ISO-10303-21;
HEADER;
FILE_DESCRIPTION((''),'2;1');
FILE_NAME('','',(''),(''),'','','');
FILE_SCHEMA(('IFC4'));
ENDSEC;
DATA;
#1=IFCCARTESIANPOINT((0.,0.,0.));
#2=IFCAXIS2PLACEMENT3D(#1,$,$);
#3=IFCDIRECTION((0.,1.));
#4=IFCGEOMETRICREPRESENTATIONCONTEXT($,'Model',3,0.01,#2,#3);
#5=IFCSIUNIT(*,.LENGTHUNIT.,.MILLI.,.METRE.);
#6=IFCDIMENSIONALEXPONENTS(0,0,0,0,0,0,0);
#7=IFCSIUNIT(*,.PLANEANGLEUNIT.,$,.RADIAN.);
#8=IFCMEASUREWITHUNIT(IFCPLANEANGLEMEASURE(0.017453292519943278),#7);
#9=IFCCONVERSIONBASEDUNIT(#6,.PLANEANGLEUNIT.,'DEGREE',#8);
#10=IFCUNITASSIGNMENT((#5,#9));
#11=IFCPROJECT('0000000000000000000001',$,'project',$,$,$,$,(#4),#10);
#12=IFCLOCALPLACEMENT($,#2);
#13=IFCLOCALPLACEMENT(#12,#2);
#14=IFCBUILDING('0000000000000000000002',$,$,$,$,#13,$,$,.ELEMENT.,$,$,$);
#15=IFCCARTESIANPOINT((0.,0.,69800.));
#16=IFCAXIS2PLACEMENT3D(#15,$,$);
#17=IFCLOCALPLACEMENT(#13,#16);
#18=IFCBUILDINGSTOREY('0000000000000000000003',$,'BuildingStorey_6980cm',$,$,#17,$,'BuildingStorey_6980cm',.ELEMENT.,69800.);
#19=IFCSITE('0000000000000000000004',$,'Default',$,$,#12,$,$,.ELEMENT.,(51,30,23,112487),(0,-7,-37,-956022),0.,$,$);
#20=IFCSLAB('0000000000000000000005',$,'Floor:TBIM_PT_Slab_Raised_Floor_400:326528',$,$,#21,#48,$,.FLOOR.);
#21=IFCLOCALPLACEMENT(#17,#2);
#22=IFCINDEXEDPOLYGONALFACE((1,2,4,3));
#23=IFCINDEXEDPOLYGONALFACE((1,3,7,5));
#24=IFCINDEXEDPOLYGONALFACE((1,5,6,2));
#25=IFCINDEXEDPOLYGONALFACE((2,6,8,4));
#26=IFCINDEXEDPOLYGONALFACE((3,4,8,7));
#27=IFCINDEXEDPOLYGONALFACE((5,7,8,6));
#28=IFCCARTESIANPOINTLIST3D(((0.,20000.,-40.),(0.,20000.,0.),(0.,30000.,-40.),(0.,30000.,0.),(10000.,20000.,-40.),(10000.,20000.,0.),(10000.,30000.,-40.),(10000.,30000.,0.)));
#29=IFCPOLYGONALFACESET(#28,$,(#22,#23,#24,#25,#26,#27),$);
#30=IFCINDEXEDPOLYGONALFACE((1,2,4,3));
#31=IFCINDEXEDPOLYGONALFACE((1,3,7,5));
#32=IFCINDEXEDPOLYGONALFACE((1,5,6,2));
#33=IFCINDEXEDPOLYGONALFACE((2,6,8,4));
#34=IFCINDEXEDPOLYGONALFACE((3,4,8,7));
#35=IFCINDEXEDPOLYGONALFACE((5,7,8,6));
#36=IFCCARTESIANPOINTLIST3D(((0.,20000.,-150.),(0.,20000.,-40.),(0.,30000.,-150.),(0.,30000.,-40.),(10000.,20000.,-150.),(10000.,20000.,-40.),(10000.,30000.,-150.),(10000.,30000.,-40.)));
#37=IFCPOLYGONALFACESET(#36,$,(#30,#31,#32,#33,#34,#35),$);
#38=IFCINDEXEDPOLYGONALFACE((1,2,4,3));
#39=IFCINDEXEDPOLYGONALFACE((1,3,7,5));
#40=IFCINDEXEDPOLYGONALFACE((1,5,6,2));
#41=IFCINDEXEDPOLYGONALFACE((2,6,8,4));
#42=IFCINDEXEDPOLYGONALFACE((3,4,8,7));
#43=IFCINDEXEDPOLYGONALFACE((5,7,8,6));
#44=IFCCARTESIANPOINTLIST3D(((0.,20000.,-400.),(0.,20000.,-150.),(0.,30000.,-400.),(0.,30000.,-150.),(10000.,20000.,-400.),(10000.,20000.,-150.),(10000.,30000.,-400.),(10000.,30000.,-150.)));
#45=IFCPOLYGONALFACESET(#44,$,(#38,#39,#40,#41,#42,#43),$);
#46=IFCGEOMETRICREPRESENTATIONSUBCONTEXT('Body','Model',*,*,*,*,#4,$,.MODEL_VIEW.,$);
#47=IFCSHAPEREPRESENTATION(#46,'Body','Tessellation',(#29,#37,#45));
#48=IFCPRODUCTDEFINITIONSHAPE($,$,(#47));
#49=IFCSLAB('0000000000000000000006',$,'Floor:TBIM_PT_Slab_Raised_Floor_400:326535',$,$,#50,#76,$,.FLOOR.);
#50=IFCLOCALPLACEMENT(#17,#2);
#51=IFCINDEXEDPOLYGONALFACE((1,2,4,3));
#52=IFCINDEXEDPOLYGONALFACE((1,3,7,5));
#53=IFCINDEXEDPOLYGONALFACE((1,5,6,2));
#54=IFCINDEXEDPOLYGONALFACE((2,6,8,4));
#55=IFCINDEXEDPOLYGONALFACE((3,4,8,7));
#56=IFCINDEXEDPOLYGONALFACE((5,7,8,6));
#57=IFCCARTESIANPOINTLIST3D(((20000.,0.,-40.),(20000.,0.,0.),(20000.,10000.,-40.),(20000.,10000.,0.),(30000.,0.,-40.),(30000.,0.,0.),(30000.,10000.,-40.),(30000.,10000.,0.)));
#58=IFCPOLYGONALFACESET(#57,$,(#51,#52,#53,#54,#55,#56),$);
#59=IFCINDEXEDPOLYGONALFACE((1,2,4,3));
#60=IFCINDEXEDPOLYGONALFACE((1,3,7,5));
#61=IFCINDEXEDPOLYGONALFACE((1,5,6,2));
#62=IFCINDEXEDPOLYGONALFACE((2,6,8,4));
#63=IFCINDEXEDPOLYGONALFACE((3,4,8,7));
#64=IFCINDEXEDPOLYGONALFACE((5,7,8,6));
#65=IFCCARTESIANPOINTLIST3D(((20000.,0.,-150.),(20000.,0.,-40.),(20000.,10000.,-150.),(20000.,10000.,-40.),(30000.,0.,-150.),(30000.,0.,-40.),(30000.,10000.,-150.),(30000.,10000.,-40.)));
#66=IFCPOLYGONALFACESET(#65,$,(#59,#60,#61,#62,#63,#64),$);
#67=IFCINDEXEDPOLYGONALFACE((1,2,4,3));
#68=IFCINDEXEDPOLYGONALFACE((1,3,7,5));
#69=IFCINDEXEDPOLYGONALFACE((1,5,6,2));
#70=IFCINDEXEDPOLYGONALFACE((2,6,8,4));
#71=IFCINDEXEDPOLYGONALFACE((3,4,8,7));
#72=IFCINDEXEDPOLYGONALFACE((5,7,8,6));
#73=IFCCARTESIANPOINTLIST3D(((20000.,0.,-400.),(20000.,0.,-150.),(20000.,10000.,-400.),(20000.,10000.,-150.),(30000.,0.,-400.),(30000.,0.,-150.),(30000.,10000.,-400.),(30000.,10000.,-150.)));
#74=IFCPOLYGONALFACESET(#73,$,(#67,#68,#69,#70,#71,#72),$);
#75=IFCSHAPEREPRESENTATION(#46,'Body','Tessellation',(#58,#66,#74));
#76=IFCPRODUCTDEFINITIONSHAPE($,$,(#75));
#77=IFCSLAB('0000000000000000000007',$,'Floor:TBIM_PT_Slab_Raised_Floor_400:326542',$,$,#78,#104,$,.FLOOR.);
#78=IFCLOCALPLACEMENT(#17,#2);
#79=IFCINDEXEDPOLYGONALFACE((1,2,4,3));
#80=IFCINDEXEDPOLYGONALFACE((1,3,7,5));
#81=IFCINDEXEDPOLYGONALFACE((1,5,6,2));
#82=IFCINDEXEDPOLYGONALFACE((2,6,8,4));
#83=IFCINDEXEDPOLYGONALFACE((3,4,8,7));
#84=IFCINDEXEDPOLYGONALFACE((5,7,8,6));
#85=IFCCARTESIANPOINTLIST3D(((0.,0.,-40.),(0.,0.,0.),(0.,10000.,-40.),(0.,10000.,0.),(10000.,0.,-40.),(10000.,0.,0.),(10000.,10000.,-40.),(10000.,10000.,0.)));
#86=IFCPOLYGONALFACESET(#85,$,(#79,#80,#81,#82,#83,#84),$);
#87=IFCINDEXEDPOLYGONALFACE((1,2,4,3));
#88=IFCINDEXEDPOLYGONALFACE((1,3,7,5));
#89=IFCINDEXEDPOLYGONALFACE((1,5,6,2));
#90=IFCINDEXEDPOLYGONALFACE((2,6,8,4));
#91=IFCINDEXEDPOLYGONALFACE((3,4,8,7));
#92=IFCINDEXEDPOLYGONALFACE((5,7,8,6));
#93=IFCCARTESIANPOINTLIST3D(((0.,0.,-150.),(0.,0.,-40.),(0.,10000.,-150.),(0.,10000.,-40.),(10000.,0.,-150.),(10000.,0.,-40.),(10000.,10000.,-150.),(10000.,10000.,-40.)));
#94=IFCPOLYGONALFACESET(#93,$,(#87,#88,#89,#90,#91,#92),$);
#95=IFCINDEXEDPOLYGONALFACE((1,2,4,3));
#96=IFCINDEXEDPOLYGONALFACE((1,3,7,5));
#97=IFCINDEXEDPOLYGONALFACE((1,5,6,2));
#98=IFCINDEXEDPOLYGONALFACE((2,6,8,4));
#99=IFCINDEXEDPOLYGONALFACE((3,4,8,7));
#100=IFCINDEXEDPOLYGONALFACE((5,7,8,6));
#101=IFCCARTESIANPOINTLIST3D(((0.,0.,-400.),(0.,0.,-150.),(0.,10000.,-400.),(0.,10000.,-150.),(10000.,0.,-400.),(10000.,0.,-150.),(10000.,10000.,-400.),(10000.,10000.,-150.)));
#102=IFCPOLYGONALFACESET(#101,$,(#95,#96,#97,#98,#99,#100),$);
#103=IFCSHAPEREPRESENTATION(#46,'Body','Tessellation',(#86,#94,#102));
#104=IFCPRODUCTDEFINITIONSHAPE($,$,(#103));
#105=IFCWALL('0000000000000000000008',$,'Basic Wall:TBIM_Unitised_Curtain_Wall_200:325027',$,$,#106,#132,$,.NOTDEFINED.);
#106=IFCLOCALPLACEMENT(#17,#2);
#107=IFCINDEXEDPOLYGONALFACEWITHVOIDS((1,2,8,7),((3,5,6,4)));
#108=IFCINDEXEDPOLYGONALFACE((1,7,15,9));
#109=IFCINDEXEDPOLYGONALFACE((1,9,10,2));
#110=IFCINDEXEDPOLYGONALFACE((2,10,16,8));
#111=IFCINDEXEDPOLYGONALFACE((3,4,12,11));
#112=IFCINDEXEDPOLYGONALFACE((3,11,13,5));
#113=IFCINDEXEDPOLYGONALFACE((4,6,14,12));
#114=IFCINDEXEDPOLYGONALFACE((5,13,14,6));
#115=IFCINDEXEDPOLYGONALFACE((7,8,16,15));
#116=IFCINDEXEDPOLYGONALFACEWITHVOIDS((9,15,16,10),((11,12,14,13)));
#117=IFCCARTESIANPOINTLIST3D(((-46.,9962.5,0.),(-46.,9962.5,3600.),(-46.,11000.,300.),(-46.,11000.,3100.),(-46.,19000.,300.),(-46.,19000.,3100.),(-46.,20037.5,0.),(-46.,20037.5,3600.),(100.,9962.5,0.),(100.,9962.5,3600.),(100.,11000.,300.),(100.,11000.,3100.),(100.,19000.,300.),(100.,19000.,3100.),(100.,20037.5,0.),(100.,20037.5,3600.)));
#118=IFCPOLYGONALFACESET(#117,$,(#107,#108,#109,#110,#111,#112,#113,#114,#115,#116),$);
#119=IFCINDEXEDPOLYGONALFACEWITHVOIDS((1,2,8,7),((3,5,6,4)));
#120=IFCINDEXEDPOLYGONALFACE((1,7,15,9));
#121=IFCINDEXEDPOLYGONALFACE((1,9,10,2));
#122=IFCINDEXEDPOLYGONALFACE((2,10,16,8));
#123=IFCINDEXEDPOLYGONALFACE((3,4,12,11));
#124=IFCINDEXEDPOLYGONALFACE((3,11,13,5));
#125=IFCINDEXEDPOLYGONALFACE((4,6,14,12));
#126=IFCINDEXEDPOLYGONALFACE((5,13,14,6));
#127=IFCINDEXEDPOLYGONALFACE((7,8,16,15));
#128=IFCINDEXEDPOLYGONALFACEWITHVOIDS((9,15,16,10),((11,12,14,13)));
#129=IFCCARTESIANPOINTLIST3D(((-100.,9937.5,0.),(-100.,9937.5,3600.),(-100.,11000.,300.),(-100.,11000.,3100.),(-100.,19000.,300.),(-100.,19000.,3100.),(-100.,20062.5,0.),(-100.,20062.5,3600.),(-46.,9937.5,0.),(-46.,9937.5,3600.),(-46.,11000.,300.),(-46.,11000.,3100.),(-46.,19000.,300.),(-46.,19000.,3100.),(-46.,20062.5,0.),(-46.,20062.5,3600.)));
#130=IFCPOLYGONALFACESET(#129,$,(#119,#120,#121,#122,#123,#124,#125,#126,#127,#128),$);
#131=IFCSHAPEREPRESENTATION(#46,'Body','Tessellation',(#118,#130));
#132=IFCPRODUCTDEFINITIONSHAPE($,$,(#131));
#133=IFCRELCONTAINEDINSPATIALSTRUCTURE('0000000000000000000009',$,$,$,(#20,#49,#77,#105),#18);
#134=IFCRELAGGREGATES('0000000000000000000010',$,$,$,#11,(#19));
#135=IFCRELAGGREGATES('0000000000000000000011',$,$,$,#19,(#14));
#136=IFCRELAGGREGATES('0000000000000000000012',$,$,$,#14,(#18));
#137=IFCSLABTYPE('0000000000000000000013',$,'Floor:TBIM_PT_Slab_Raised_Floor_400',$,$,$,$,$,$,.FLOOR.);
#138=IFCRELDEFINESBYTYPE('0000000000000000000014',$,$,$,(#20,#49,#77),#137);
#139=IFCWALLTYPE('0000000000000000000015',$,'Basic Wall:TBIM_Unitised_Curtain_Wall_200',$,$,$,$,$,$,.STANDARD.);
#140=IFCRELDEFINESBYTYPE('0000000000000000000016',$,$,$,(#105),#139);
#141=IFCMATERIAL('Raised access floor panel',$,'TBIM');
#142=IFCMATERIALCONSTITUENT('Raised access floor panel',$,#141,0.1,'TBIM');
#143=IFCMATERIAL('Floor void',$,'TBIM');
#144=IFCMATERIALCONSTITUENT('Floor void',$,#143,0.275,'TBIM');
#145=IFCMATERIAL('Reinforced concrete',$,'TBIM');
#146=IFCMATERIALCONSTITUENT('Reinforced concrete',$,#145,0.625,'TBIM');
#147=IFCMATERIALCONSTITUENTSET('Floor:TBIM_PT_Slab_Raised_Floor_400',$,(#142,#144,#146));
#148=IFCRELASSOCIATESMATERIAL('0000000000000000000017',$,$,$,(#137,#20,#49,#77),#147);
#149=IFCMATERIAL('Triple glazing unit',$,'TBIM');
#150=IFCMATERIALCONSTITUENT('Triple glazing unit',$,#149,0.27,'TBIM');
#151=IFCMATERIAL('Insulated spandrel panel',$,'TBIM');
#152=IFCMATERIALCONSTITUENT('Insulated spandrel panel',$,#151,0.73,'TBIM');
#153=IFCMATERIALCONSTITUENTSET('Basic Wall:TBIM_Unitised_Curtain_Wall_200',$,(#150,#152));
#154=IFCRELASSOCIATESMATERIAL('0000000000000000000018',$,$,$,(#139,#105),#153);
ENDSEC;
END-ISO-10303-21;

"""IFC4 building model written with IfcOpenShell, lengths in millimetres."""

from ifc_helpers import new_model, entity, si_unit, converted_unit, direction, frame, origin, place, context, subcontext, project, spatial, indexed_curve, outline, extrude, material, constituent, constituent_set, type_object, element, save


model = new_model("IFC4")

# Units and contexts
model_context = context("Model", 3, precision=0.01, world=origin(), true_north=direction((0.0, 1.0)))
body_context = subcontext(model_context, "Body", "Model", "MODEL_VIEW")
ifc_project = project(units=[si_unit("LENGTHUNIT", "METRE", prefix="MILLI"), converted_unit("PLANEANGLEUNIT", "DEGREE", entity("IfcPlaneAngleMeasure", 0.017453292519943278), si_unit("PLANEANGLEUNIT", "RADIAN"), dimensions=[0, 0, 0, 0, 0, 0, 0])], contexts=[model_context])

# Site, building, storey
site_placement = place(None, origin())
site = spatial("IfcSite", under=ifc_project, at=site_placement, Name="Default", CompositionType="ELEMENT", RefLatitude=(51, 30, 23, 112487), RefLongitude=(0, -7, -37, -956022), RefElevation=0.0)
building_placement = place(site_placement, origin())
building = spatial("IfcBuilding", under=site, at=building_placement, CompositionType="ELEMENT")
storey_placement = place(building_placement, frame((0.0, 0.0, 69800.0)))
storey = spatial("IfcBuildingStorey", under=building, at=storey_placement, Name="BuildingStorey_6980cm", LongName="BuildingStorey_6980cm", CompositionType="ELEMENT", Elevation=69800.0)

# Slabs
ifc_material_1 = material(Name="Raised access floor panel", Category="TBIM")
ifc_constituent_1 = constituent(ifc_material_1, Name="Raised access floor panel", Category="TBIM", fraction=0.1)
ifc_material_2 = material(Name="Floor void", Category="TBIM")
ifc_constituent_2 = constituent(ifc_material_2, Name="Floor void", Category="TBIM", fraction=0.275)
ifc_material_3 = material(Name="Reinforced concrete", Category="TBIM")
ifc_constituent_3 = constituent(ifc_material_3, Name="Reinforced concrete", Category="TBIM", fraction=0.625)
ifc_constituent_set_1 = constituent_set(constituents=[ifc_constituent_1, ifc_constituent_2, ifc_constituent_3], Name="Floor:TBIM_PT_Slab_Raised_Floor_400")
slab_type = type_object("IfcSlabType", Name="Floor:TBIM_PT_Slab_Raised_Floor_400", PredefinedType="FLOOR", material=ifc_constituent_set_1)
slab_1_placement = place(storey_placement, origin())
element("IfcSlab", 1, at=slab_1_placement, inside=storey, type_object=slab_type, material=ifc_constituent_set_1, Name="Floor:TBIM_PT_Slab_Raised_Floor_400:326528", PredefinedType="FLOOR", context=body_context, shape_type="SweptSolid", body=[
    extrude(outline(indexed_curve([(-5000.0, -5000.0), (5000.0, -5000.0), (5000.0, 5000.0), (-5000.0, 5000.0), (-5000.0, -5000.0)], self_intersect=False)), frame((5000.0, 25000.0, -40.0), z_axis=(0.0, 0.0, 1.0), x_axis=(-1.0, 0.0, 0.0)), (0.0, 0.0, 1.0), 40.0),
    extrude(outline(indexed_curve([(-5000.0, -5000.0), (5000.0, -5000.0), (5000.0, 5000.0), (-5000.0, 5000.0), (-5000.0, -5000.0)], self_intersect=False)), frame((5000.0, 25000.0, -150.0), z_axis=(0.0, 0.0, 1.0), x_axis=(-1.0, 0.0, 0.0)), (0.0, 0.0, 1.0), 110.0),
    extrude(outline(indexed_curve([(-5000.0, -5000.0), (5000.0, -5000.0), (5000.0, 5000.0), (-5000.0, 5000.0), (-5000.0, -5000.0)], self_intersect=False)), frame((5000.0, 25000.0, -400.0), z_axis=(0.0, 0.0, 1.0), x_axis=(-1.0, 0.0, 0.0)), (0.0, 0.0, 1.0), 250.0),
])
slab_2_placement = place(storey_placement, origin())
element("IfcSlab", 2, at=slab_2_placement, inside=storey, type_object=slab_type, material=ifc_constituent_set_1, Name="Floor:TBIM_PT_Slab_Raised_Floor_400:326535", PredefinedType="FLOOR", context=body_context, shape_type="SweptSolid", body=[
    extrude(outline(indexed_curve([(-5000.0, -5000.0), (5000.0, -5000.0), (5000.0, 5000.0), (-5000.0, 5000.0), (-5000.0, -5000.0)], self_intersect=False)), frame((25000.0, 5000.0, -40.0), z_axis=(0.0, 0.0, 1.0), x_axis=(-1.0, 0.0, 0.0)), (0.0, 0.0, 1.0), 40.0),
    extrude(outline(indexed_curve([(-5000.0, -5000.0), (5000.0, -5000.0), (5000.0, 5000.0), (-5000.0, 5000.0), (-5000.0, -5000.0)], self_intersect=False)), frame((25000.0, 5000.0, -150.0), z_axis=(0.0, 0.0, 1.0), x_axis=(-1.0, 0.0, 0.0)), (0.0, 0.0, 1.0), 110.0),
    extrude(outline(indexed_curve([(-5000.0, -5000.0), (5000.0, -5000.0), (5000.0, 5000.0), (-5000.0, 5000.0), (-5000.0, -5000.0)], self_intersect=False)), frame((25000.0, 5000.0, -400.0), z_axis=(0.0, 0.0, 1.0), x_axis=(-1.0, 0.0, 0.0)), (0.0, 0.0, 1.0), 250.0),
])
slab_3_placement = place(storey_placement, origin())
element("IfcSlab", 3, at=slab_3_placement, inside=storey, type_object=slab_type, material=ifc_constituent_set_1, Name="Floor:TBIM_PT_Slab_Raised_Floor_400:326542", PredefinedType="FLOOR", context=body_context, shape_type="SweptSolid", body=[
    extrude(outline(indexed_curve([(-5000.0, -5000.0), (5000.0, -5000.0), (5000.0, 5000.0), (-5000.0, 5000.0), (-5000.0, -5000.0)], self_intersect=False)), frame((5000.0, 5000.0, -40.0), z_axis=(0.0, 0.0, 1.0), x_axis=(-1.0, 0.0, 0.0)), (0.0, 0.0, 1.0), 40.0),
    extrude(outline(indexed_curve([(-5000.0, -5000.0), (5000.0, -5000.0), (5000.0, 5000.0), (-5000.0, 5000.0), (-5000.0, -5000.0)], self_intersect=False)), frame((5000.0, 5000.0, -150.0), z_axis=(0.0, 0.0, 1.0), x_axis=(-1.0, 0.0, 0.0)), (0.0, 0.0, 1.0), 110.0),
    extrude(outline(indexed_curve([(-5000.0, -5000.0), (5000.0, -5000.0), (5000.0, 5000.0), (-5000.0, 5000.0), (-5000.0, -5000.0)], self_intersect=False)), frame((5000.0, 5000.0, -400.0), z_axis=(0.0, 0.0, 1.0), x_axis=(-1.0, 0.0, 0.0)), (0.0, 0.0, 1.0), 250.0),
])

# Wall, opening
ifc_material_4 = material(Name="Triple glazing unit", Category="TBIM")
ifc_constituent_4 = constituent(ifc_material_4, Name="Triple glazing unit", Category="TBIM", fraction=0.27)
ifc_material_5 = material(Name="Insulated spandrel panel", Category="TBIM")
ifc_constituent_5 = constituent(ifc_material_5, Name="Insulated spandrel panel", Category="TBIM", fraction=0.73)
ifc_constituent_set_2 = constituent_set(constituents=[ifc_constituent_4, ifc_constituent_5], Name="Basic Wall:TBIM_Unitised_Curtain_Wall_200")
wall_type = type_object("IfcWallType", Name="Basic Wall:TBIM_Unitised_Curtain_Wall_200", PredefinedType="STANDARD", material=ifc_constituent_set_2)
wall_1_placement = place(storey_placement, frame((0.0, 9937.5, 0.0), z_axis=(0.0, 0.0, 1.0), x_axis=(0.0, 1.0, 0.0)))
wall_1 = element("IfcWall", 4, at=wall_1_placement, inside=storey, type_object=wall_type, material=ifc_constituent_set_2, Name="Basic Wall:TBIM_Unitised_Curtain_Wall_200:325027", PredefinedType="NOTDEFINED", context=body_context, shape_type="SweptSolid", body=[
    extrude(outline(indexed_curve([(-1800.0, -5037.5), (1800.0, -5037.5), (1800.0, 5037.5), (-1800.0, 5037.5), (-1800.0, -5037.5)], self_intersect=False), holes=[indexed_curve([(1300.0, 4000.0), (1300.0, -4000.0), (-1500.0, -4000.0), (-1500.0, 4000.0), (1300.0, 4000.0)], self_intersect=False)]), frame((5062.5, 46.0, 1800.0), z_axis=(0.0, -1.0, 0.0), x_axis=(0.0, 0.0, 1.0)), (0.0, 0.0, 1.0), 146.0),
    extrude(outline(indexed_curve([(-5062.5, -1800.0), (5062.5, -1800.0), (5062.5, 1800.0), (-5062.5, 1800.0), (-5062.5, -1800.0)], self_intersect=False), holes=[indexed_curve([(-4000.0, 1300.0), (4000.0, 1300.0), (4000.0, -1500.0), (-4000.0, -1500.0), (-4000.0, 1300.0)], self_intersect=False)]), frame((5062.5, 100.0, 1800.0), z_axis=(0.0, -1.0, 0.0), x_axis=(1.0, 0.0, 0.0)), (0.0, 0.0, 1.0), 54.0),
])
opening_1_placement = place(wall_1_placement, frame((1062.5, -100.0, 300.0)))
element("IfcOpeningElement", 5, at=opening_1_placement, cuts=wall_1, PredefinedType="OPENING", context=body_context, shape_type="SweptSolid", body=[
    extrude(outline(indexed_curve([(2800.0, 0.0), (2800.0, 8000.0), (0.0, 8000.0), (0.0, 0.0), (2800.0, 0.0)], self_intersect=False)), frame((0.0, 0.0, 0.0), z_axis=(0.0, 1.0, 0.0), x_axis=(0.0, 0.0, 1.0)), (0.0, 0.0, 1.0), 200.0),
])

save(model, "model.ifc")
